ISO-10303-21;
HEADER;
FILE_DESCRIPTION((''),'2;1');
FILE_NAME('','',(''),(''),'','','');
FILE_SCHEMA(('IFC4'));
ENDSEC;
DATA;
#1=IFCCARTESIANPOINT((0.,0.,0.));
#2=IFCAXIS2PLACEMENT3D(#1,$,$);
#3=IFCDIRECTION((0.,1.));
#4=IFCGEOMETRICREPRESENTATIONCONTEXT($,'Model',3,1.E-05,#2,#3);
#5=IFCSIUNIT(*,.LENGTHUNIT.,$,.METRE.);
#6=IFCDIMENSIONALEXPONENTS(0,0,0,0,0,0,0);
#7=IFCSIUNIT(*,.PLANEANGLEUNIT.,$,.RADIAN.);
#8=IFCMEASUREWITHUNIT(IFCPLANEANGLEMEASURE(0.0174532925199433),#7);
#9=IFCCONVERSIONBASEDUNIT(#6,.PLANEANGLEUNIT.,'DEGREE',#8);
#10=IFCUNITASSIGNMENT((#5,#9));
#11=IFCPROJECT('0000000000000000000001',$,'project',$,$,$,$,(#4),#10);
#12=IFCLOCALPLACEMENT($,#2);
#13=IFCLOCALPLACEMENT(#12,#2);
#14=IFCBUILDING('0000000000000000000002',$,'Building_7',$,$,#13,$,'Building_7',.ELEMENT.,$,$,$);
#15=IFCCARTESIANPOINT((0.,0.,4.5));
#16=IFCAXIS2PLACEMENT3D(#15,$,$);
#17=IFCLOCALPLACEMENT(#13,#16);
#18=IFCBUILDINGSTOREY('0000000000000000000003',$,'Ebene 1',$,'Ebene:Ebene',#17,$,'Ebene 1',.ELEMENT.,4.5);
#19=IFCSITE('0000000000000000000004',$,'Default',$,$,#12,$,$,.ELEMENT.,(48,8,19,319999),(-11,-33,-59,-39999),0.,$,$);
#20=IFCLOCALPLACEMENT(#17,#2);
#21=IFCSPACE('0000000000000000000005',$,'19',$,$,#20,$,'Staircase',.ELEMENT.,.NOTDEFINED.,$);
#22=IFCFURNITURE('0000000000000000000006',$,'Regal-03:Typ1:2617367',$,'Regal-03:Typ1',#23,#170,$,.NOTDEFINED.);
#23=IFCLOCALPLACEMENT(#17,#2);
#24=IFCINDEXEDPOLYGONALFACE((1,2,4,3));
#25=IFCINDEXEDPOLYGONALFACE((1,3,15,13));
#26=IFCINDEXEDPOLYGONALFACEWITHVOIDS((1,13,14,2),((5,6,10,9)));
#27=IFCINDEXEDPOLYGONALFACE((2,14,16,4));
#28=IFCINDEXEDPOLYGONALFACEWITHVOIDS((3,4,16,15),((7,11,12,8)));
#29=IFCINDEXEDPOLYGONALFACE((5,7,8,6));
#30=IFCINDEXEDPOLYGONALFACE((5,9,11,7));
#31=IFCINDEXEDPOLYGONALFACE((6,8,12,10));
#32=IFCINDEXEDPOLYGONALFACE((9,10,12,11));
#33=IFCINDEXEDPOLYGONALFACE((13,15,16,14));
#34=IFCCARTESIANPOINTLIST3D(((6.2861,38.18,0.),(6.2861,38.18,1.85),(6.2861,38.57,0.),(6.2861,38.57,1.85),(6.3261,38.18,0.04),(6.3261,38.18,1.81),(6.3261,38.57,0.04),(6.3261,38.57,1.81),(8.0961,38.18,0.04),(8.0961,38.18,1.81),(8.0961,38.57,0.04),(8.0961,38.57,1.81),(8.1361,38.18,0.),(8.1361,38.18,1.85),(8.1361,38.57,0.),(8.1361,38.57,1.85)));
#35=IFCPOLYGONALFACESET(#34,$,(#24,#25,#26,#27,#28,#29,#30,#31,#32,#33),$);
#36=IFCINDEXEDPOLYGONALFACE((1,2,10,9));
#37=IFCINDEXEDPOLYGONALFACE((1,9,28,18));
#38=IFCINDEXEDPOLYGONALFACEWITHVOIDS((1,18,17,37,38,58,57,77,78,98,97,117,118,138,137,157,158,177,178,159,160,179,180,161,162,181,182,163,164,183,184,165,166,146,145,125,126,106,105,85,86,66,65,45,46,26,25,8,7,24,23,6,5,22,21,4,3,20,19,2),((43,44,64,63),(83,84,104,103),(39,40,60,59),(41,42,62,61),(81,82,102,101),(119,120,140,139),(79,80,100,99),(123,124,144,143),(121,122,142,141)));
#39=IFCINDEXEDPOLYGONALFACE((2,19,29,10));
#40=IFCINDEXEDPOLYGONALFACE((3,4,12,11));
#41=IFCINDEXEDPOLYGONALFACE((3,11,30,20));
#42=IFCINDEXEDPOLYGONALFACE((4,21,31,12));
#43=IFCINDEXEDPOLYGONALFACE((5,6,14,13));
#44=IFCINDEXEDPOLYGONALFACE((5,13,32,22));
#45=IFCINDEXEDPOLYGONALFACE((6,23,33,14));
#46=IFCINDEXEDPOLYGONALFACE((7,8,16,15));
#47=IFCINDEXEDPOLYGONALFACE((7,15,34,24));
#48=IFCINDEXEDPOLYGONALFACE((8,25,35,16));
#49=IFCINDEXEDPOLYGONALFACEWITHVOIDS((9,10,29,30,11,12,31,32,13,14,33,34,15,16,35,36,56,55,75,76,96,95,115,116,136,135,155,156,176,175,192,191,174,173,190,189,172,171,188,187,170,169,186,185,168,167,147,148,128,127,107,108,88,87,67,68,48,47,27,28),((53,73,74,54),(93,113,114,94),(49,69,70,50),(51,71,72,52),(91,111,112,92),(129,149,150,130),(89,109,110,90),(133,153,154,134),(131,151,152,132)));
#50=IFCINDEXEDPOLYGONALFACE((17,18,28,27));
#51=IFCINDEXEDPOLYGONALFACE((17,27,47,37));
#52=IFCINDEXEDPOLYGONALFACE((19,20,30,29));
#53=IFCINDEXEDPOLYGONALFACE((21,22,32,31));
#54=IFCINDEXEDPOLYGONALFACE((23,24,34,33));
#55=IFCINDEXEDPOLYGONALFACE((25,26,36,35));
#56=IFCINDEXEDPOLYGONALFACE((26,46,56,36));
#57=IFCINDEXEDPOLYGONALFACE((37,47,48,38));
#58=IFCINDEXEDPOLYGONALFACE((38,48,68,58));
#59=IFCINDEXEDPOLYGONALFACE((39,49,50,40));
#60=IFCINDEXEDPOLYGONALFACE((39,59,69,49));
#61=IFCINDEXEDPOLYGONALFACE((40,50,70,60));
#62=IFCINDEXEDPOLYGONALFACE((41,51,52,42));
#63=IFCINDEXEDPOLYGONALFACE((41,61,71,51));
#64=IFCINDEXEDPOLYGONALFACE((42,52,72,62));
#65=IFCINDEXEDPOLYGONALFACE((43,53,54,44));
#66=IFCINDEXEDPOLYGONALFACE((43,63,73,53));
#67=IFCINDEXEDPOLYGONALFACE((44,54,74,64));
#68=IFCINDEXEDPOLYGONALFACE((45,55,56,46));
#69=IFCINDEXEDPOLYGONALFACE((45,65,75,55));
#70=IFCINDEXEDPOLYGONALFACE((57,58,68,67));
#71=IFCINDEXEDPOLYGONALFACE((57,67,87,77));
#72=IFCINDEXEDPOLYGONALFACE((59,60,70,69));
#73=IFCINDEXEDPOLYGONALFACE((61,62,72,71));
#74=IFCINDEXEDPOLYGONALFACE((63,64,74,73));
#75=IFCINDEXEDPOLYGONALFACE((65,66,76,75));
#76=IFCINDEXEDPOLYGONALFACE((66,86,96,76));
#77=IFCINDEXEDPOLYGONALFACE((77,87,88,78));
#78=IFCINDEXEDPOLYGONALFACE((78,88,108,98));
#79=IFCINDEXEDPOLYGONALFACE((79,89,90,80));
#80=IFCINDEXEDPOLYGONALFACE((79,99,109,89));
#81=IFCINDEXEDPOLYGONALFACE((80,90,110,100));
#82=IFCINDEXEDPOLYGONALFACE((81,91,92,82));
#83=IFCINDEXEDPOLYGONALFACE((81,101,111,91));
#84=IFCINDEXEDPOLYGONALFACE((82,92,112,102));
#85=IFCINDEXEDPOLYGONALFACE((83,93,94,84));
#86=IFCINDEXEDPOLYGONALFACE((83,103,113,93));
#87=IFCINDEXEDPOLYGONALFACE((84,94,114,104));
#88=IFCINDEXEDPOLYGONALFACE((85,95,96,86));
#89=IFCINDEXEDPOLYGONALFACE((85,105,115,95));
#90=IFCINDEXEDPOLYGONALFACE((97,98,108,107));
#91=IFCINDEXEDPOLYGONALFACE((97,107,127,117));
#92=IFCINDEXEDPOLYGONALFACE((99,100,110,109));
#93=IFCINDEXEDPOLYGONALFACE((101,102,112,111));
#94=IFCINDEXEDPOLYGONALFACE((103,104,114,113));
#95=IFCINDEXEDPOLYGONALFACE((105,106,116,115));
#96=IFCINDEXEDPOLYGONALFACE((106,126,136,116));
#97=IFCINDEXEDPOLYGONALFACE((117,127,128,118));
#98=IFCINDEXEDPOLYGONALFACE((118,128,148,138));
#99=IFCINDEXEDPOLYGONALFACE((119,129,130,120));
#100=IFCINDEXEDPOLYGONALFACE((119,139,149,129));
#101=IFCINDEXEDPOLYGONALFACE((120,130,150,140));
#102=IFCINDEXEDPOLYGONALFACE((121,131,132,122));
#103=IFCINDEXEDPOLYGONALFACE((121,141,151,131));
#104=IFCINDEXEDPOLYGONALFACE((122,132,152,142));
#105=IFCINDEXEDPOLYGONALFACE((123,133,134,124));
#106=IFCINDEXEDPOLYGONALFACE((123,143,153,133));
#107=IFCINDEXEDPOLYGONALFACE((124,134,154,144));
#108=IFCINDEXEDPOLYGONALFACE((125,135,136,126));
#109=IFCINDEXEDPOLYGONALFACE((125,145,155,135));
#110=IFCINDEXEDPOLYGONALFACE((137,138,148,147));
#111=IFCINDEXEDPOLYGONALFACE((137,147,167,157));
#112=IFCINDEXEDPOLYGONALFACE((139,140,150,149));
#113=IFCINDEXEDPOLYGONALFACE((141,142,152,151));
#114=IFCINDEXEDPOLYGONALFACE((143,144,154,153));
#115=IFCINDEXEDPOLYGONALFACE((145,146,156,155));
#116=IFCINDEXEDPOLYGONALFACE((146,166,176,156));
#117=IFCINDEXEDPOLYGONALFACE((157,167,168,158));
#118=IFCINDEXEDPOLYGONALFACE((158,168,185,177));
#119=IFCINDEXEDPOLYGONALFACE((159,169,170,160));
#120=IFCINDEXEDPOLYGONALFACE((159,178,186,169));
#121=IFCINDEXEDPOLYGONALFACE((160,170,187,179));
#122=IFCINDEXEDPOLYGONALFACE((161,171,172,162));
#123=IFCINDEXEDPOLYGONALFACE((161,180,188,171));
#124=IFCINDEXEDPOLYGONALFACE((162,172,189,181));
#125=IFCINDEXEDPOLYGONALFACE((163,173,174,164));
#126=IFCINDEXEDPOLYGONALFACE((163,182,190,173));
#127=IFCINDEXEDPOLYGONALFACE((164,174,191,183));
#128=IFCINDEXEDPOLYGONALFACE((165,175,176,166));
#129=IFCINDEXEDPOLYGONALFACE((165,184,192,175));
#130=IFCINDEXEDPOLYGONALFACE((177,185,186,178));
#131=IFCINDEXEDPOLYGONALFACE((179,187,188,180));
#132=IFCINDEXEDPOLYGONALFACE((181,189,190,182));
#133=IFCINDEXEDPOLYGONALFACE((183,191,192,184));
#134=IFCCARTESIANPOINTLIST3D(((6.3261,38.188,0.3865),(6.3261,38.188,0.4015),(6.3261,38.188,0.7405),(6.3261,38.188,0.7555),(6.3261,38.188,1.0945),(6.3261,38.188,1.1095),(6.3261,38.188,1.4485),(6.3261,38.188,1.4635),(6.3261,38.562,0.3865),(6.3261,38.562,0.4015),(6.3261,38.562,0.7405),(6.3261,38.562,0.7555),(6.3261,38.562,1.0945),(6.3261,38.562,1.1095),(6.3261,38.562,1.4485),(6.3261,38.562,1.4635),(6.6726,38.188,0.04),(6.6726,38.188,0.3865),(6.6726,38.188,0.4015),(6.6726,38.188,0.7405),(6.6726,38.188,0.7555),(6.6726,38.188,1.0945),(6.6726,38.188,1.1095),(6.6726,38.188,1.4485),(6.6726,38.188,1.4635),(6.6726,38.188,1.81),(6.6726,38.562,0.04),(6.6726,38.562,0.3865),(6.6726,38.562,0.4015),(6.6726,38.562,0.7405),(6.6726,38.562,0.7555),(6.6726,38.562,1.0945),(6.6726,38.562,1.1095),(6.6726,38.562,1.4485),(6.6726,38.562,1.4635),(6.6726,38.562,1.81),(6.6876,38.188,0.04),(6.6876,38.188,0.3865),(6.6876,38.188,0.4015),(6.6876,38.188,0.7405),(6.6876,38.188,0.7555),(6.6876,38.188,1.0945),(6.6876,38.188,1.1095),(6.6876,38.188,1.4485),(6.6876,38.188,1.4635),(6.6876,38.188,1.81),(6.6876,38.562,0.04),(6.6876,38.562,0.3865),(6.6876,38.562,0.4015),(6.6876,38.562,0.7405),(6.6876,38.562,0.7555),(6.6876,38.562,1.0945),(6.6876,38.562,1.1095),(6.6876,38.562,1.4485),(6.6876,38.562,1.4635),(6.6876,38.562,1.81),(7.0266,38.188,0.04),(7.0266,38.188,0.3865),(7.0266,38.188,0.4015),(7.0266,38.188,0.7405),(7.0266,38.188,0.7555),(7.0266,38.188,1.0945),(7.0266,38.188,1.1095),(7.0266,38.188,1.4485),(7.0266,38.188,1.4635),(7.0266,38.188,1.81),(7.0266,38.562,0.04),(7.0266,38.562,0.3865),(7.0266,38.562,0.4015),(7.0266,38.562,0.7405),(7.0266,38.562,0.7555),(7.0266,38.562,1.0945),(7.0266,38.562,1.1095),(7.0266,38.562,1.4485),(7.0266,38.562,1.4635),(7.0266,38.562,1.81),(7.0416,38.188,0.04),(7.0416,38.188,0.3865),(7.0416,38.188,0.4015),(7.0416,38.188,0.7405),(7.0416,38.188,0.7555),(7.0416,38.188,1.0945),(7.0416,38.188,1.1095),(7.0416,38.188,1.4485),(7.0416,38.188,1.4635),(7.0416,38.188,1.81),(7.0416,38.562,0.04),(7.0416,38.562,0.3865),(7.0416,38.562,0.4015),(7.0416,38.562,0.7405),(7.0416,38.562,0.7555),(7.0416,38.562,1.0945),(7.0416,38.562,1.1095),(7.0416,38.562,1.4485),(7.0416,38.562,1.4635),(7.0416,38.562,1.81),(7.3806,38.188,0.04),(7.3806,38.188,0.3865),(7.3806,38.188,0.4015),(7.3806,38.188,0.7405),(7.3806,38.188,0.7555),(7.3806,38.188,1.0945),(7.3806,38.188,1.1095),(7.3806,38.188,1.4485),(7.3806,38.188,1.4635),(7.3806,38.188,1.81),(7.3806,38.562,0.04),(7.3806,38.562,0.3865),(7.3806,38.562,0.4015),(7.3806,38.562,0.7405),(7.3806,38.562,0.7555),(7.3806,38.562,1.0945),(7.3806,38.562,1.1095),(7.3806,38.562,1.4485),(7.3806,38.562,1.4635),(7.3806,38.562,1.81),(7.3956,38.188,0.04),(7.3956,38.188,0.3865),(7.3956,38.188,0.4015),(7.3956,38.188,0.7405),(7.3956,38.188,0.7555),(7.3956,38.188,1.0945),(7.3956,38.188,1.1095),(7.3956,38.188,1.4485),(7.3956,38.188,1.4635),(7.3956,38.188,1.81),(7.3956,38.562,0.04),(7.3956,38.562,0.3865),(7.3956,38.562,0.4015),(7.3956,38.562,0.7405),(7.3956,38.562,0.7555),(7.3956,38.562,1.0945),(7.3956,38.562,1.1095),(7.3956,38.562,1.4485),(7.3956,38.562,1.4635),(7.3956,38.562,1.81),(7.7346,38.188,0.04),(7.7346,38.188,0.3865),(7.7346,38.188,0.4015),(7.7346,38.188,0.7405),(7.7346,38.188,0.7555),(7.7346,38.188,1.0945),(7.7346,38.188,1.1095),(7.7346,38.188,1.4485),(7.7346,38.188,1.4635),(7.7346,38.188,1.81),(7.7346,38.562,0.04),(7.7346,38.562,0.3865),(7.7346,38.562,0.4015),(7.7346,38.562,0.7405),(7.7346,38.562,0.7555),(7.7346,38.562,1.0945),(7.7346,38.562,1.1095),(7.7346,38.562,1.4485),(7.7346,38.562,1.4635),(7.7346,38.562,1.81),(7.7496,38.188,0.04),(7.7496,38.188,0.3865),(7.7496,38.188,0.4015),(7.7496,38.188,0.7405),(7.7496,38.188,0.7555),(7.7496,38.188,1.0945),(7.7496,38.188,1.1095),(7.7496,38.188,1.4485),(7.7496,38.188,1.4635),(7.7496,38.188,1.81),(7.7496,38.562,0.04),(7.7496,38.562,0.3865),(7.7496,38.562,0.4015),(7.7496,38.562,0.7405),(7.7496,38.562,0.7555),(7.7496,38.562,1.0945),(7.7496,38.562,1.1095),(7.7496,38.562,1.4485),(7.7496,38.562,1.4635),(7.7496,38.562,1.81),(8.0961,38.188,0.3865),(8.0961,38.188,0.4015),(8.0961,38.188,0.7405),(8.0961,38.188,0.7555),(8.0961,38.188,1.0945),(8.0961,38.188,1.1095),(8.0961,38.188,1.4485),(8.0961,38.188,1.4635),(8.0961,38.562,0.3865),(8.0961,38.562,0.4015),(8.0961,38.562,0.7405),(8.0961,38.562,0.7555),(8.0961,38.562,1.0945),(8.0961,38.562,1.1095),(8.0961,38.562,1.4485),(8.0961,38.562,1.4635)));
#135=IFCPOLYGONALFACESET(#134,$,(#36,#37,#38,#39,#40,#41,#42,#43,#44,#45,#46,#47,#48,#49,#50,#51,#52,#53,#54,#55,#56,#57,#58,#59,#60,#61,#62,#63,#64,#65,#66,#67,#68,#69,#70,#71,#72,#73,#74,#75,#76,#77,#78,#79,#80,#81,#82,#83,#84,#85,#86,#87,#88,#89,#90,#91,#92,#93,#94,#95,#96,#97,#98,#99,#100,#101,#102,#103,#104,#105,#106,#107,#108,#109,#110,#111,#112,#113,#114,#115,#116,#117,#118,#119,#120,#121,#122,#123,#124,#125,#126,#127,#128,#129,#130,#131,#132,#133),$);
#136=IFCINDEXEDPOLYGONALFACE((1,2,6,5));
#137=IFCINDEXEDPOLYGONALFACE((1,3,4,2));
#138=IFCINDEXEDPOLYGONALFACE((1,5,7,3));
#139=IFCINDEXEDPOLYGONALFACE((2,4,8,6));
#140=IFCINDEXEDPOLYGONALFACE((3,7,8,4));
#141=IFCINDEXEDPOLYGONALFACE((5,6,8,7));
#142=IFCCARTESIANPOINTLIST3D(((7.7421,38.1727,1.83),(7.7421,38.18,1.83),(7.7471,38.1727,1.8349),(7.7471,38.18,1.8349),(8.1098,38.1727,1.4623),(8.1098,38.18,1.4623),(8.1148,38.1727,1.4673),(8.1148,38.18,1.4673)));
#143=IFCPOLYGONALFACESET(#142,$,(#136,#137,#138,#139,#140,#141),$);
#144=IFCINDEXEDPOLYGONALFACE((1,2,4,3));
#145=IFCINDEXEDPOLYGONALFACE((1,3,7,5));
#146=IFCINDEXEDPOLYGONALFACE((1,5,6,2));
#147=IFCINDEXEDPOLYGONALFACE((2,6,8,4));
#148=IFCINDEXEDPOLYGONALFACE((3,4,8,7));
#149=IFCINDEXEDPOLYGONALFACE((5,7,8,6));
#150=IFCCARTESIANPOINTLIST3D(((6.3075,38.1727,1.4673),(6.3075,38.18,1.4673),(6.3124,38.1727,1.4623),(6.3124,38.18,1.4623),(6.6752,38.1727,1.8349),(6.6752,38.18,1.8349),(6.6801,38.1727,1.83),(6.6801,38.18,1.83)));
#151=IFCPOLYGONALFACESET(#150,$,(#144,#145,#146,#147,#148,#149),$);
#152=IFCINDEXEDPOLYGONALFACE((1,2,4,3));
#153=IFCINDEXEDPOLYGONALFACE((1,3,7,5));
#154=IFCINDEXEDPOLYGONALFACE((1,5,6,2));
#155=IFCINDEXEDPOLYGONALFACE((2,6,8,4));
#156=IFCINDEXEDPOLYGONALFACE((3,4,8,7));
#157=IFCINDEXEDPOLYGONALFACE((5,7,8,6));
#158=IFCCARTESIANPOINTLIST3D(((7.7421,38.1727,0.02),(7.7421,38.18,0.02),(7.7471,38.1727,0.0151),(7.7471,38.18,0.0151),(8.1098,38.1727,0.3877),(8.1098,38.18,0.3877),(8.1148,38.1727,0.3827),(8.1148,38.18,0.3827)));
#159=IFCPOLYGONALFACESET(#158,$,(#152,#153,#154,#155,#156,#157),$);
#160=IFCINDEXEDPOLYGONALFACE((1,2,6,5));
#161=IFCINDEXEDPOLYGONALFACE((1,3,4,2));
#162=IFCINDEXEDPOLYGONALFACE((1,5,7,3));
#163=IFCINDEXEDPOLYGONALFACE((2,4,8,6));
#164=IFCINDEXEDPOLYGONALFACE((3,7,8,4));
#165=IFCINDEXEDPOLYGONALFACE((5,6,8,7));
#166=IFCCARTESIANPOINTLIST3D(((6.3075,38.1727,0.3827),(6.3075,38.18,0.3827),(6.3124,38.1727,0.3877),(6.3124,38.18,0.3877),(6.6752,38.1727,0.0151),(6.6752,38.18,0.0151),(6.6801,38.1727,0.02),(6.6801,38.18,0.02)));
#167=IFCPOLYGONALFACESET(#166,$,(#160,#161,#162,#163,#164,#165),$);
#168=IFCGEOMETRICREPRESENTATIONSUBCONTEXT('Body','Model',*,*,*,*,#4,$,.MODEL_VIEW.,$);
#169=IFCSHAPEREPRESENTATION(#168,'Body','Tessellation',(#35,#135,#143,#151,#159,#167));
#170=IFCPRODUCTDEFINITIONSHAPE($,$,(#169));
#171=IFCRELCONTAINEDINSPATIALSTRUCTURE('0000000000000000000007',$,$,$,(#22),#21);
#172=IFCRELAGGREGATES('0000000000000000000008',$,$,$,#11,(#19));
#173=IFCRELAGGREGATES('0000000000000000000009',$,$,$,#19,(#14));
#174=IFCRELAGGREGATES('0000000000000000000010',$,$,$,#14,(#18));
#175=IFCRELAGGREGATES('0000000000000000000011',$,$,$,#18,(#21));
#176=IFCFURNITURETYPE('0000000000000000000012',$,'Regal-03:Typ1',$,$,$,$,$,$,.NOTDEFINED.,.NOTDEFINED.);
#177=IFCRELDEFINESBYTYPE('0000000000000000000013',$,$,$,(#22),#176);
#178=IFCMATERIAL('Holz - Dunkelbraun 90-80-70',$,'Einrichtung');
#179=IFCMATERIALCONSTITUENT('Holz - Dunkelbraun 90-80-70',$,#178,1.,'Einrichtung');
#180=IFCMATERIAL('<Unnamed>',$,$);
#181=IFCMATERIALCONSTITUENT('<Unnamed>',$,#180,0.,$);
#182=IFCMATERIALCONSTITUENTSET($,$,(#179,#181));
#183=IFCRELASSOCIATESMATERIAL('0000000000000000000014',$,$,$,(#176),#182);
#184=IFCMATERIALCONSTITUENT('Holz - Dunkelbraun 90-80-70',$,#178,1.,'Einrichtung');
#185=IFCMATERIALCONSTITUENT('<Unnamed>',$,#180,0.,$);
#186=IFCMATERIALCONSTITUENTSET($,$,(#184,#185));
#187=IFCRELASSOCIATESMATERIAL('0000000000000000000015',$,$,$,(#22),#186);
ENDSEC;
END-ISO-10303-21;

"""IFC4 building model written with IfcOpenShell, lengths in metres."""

from ifc_helpers import new_model, entity, si_unit, converted_unit, direction, frame, origin, place, context, subcontext, project, spatial, indexed_curve, outline, extrude, source, transform, mapped, material, constituent, constituent_set, type_object, type_shapes, element, save


model = new_model("IFC4")

# Units and contexts
model_context = context("Model", 3, precision=1e-05, world=origin(), true_north=direction((0.0, 1.0)))
body_context = subcontext(model_context, "Body", "Model", "MODEL_VIEW")
ifc_project = project(units=[si_unit("LENGTHUNIT", "METRE"), converted_unit("PLANEANGLEUNIT", "DEGREE", entity("IfcPlaneAngleMeasure", 0.0174532925199433), si_unit("PLANEANGLEUNIT", "RADIAN"), dimensions=[0, 0, 0, 0, 0, 0, 0])], contexts=[model_context])

# Site, building, storey
site_placement = place(None, origin())
site = spatial("IfcSite", under=ifc_project, at=site_placement, Name="Default", CompositionType="ELEMENT", RefLatitude=(48, 8, 19, 319999), RefLongitude=(-11, -33, -59, -39999), RefElevation=0.0)
building_placement = place(site_placement, origin())
building = spatial("IfcBuilding", under=site, at=building_placement, Name="Building_7", LongName="Building_7", CompositionType="ELEMENT")
storey_placement = place(building_placement, frame((0.0, 0.0, 4.5)))
storey = spatial("IfcBuildingStorey", under=building, at=storey_placement, Name="Ebene 1", ObjectType="Ebene:Ebene", LongName="Ebene 1", CompositionType="ELEMENT", Elevation=4.5)

# Shared definitions
ifc_material_1 = material(Name="<Unnamed>")

# Shared definitions
ifc_material_2 = material(Name="Holz - Dunkelbraun 90-80-70", Category="Einrichtung")

# Shared definitions
space_1_placement = place(storey_placement, origin())
space_1 = spatial("IfcSpace", under=storey, at=space_1_placement, Name="19", LongName="Staircase", CompositionType="ELEMENT", PredefinedType="NOTDEFINED")

# Furniture
ifc_constituent_1 = constituent(ifc_material_2, Name="Holz - Dunkelbraun 90-80-70", Category="Einrichtung", fraction=1.0)
ifc_constituent_2 = constituent(ifc_material_1, Name="<Unnamed>", fraction=0.0)
ifc_constituent_set_1 = constituent_set(constituents=[ifc_constituent_1, ifc_constituent_2])
ifc_constituent_3 = constituent(ifc_material_2, Name="Holz - Dunkelbraun 90-80-70", Category="Einrichtung", fraction=1.0)
ifc_constituent_4 = constituent(ifc_material_1, Name="<Unnamed>", fraction=0.0)
ifc_constituent_set_2 = constituent_set(constituents=[ifc_constituent_3, ifc_constituent_4])
furniture_type_1 = type_object("IfcFurnitureType", Name="Regal-03:Typ1", AssemblyPlace="NOTDEFINED", PredefinedType="NOTDEFINED", material=ifc_constituent_set_2)
shared_shape_1 = source(origin(), body_context, "Body", "SweptSolid", [
    extrude(outline(indexed_curve([(-0.925, -0.925), (0.925, -0.925), (0.925, 0.925), (-0.925, 0.925), (-0.925, -0.925)], self_intersect=False), holes=[indexed_curve([(-0.885, -0.885), (-0.885, 0.885), (0.885, 0.885), (0.885, -0.885), (-0.885, -0.885)], self_intersect=False)]), frame((0.2471, -0.1249, 0.925), z_axis=(0.0, 1.0, 0.0), x_axis=(0.0, 0.0, -1.0)), (0.0, 0.0, 1.0), 0.39),
    extrude(outline(indexed_curve([(0.5385, -0.5385), (0.885, -0.5385), (0.885, -0.5235), (0.5385, -0.5235), (0.5385, -0.1845), (0.885, -0.1845), (0.885, -0.1695), (0.5385, -0.1695), (0.5385, 0.1695), (0.885, 0.1695), (0.885, 0.1845), (0.5385, 0.1845), (0.5385, 0.5235), (0.885, 0.5235), (0.885, 0.5385), (0.5385, 0.5385), (0.5385, 0.885), (0.5235, 0.885), (0.5235, 0.5385), (0.1845, 0.5385), (0.1845, 0.885), (0.1695, 0.885), (0.1695, 0.5385), (-0.1695, 0.5385), (-0.1695, 0.885), (-0.1845, 0.885), (-0.1845, 0.5385), (-0.5235, 0.5385), (-0.5235, 0.885), (-0.5385, 0.885), (-0.5385, 0.5385), (-0.885, 0.5385), (-0.885, 0.5235), (-0.5385, 0.5235), (-0.5385, 0.1845), (-0.885, 0.1845), (-0.885, 0.1695), (-0.5385, 0.1695), (-0.5385, -0.1695), (-0.885, -0.1695), (-0.885, -0.1845), (-0.5385, -0.1845), (-0.5385, -0.5235), (-0.885, -0.5235), (-0.885, -0.5385), (-0.5385, -0.5385), (-0.5385, -0.885), (-0.5235, -0.885), (-0.5235, -0.5385), (-0.1845, -0.5385), (-0.1845, -0.885), (-0.1695, -0.885), (-0.1695, -0.5385), (0.1695, -0.5385), (0.1695, -0.885), (0.1845, -0.885), (0.1845, -0.5385), (0.5235, -0.5385), (0.5235, -0.885), (0.5385, -0.885), (0.5385, -0.5385)], self_intersect=False), holes=[indexed_curve([(0.5235, -0.1845), (0.5235, -0.5235), (0.1845, -0.5235), (0.1845, -0.1845), (0.5235, -0.1845)], self_intersect=False), indexed_curve([(0.1845, -0.1695), (0.1845, 0.1695), (0.5235, 0.1695), (0.5235, -0.1695), (0.1845, -0.1695)], self_intersect=False), indexed_curve([(0.1845, 0.1845), (0.1845, 0.5235), (0.5235, 0.5235), (0.5235, 0.1845), (0.1845, 0.1845)], self_intersect=False), indexed_curve([(-0.1695, 0.5235), (0.1695, 0.5235), (0.1695, 0.1845), (-0.1695, 0.1845), (-0.1695, 0.5235)], self_intersect=False), indexed_curve([(-0.1695, 0.1695), (0.1695, 0.1695), (0.1695, -0.1695), (-0.1695, -0.1695), (-0.1695, 0.1695)], self_intersect=False), indexed_curve([(-0.1695, -0.1845), (0.1695, -0.1845), (0.1695, -0.5235), (-0.1695, -0.5235), (-0.1695, -0.1845)], self_intersect=False), indexed_curve([(-0.5235, -0.5235), (-0.5235, -0.1845), (-0.1845, -0.1845), (-0.1845, -0.5235), (-0.5235, -0.5235)], self_intersect=False), indexed_curve([(-0.5235, -0.1695), (-0.5235, 0.1695), (-0.1845, 0.1695), (-0.1845, -0.1695), (-0.5235, -0.1695)], self_intersect=False), indexed_curve([(-0.5235, 0.1845), (-0.5235, 0.5235), (-0.1845, 0.5235), (-0.1845, 0.1845), (-0.5235, 0.1845)], self_intersect=False)]), frame((0.2471, -0.1169, 0.925), z_axis=(0.0, 1.0, 0.0), x_axis=(0.0, 0.0, 1.0)), (0.0, 0.0, 1.0), 0.374),
    extrude(outline(indexed_curve([(-0.0035, -0.0037), (0.0035, -0.0037), (0.0035, 0.0037), (-0.0035, 0.0037), (-0.0035, -0.0037)], self_intersect=False)), frame((1.1482, -0.1286, 1.4648), z_axis=(-0.707107, 0.0, 0.707107), x_axis=(-0.707107, 0.0, -0.707107)), (0.0, 0.0, 1.0), 0.52),
    extrude(outline(indexed_curve([(-0.0035, -0.0037), (0.0035, -0.0037), (0.0035, 0.0037), (-0.0035, 0.0037), (-0.0035, -0.0037)], self_intersect=False)), frame((-0.6541, -0.1286, 1.4648), z_axis=(0.707107, 0.0, 0.707107), x_axis=(-0.707107, 0.0, 0.707107)), (0.0, 0.0, 1.0), 0.52),
    extrude(outline(indexed_curve([(-0.0035, -0.0037), (0.0035, -0.0037), (0.0035, 0.0037), (-0.0035, 0.0037), (-0.0035, -0.0037)], self_intersect=False)), frame((0.7805, -0.1286, 0.0175), z_axis=(0.707107, 0.0, 0.707107), x_axis=(-0.707107, 0.0, 0.707107)), (0.0, 0.0, 1.0), 0.52),
    extrude(outline(indexed_curve([(-0.0035, -0.0037), (0.0035, -0.0037), (0.0035, 0.0037), (-0.0035, 0.0037), (-0.0035, -0.0037)], self_intersect=False)), frame((-0.2864, -0.1286, 0.0175), z_axis=(-0.707107, 0.0, 0.707107), x_axis=(-0.707107, 0.0, -0.707107)), (0.0, 0.0, 1.0), 0.52),
])
type_shapes(furniture_type_1, [shared_shape_1])
furniture_1_placement = place(space_1_placement, frame((6.9641, 38.3049, 0.0)))
element("IfcFurniture", 1, at=furniture_1_placement, inside=space_1, type_object=furniture_type_1, material=ifc_constituent_set_1, Name="Regal-03:Typ1:2617367", ObjectType="Regal-03:Typ1", PredefinedType="NOTDEFINED", context=body_context, shape_type="MappedRepresentation", body=[
    mapped(shared_shape_1, transform((0.0, 0.0, 0.0), scale=1.0)),
])

save(model, "model.ifc")
